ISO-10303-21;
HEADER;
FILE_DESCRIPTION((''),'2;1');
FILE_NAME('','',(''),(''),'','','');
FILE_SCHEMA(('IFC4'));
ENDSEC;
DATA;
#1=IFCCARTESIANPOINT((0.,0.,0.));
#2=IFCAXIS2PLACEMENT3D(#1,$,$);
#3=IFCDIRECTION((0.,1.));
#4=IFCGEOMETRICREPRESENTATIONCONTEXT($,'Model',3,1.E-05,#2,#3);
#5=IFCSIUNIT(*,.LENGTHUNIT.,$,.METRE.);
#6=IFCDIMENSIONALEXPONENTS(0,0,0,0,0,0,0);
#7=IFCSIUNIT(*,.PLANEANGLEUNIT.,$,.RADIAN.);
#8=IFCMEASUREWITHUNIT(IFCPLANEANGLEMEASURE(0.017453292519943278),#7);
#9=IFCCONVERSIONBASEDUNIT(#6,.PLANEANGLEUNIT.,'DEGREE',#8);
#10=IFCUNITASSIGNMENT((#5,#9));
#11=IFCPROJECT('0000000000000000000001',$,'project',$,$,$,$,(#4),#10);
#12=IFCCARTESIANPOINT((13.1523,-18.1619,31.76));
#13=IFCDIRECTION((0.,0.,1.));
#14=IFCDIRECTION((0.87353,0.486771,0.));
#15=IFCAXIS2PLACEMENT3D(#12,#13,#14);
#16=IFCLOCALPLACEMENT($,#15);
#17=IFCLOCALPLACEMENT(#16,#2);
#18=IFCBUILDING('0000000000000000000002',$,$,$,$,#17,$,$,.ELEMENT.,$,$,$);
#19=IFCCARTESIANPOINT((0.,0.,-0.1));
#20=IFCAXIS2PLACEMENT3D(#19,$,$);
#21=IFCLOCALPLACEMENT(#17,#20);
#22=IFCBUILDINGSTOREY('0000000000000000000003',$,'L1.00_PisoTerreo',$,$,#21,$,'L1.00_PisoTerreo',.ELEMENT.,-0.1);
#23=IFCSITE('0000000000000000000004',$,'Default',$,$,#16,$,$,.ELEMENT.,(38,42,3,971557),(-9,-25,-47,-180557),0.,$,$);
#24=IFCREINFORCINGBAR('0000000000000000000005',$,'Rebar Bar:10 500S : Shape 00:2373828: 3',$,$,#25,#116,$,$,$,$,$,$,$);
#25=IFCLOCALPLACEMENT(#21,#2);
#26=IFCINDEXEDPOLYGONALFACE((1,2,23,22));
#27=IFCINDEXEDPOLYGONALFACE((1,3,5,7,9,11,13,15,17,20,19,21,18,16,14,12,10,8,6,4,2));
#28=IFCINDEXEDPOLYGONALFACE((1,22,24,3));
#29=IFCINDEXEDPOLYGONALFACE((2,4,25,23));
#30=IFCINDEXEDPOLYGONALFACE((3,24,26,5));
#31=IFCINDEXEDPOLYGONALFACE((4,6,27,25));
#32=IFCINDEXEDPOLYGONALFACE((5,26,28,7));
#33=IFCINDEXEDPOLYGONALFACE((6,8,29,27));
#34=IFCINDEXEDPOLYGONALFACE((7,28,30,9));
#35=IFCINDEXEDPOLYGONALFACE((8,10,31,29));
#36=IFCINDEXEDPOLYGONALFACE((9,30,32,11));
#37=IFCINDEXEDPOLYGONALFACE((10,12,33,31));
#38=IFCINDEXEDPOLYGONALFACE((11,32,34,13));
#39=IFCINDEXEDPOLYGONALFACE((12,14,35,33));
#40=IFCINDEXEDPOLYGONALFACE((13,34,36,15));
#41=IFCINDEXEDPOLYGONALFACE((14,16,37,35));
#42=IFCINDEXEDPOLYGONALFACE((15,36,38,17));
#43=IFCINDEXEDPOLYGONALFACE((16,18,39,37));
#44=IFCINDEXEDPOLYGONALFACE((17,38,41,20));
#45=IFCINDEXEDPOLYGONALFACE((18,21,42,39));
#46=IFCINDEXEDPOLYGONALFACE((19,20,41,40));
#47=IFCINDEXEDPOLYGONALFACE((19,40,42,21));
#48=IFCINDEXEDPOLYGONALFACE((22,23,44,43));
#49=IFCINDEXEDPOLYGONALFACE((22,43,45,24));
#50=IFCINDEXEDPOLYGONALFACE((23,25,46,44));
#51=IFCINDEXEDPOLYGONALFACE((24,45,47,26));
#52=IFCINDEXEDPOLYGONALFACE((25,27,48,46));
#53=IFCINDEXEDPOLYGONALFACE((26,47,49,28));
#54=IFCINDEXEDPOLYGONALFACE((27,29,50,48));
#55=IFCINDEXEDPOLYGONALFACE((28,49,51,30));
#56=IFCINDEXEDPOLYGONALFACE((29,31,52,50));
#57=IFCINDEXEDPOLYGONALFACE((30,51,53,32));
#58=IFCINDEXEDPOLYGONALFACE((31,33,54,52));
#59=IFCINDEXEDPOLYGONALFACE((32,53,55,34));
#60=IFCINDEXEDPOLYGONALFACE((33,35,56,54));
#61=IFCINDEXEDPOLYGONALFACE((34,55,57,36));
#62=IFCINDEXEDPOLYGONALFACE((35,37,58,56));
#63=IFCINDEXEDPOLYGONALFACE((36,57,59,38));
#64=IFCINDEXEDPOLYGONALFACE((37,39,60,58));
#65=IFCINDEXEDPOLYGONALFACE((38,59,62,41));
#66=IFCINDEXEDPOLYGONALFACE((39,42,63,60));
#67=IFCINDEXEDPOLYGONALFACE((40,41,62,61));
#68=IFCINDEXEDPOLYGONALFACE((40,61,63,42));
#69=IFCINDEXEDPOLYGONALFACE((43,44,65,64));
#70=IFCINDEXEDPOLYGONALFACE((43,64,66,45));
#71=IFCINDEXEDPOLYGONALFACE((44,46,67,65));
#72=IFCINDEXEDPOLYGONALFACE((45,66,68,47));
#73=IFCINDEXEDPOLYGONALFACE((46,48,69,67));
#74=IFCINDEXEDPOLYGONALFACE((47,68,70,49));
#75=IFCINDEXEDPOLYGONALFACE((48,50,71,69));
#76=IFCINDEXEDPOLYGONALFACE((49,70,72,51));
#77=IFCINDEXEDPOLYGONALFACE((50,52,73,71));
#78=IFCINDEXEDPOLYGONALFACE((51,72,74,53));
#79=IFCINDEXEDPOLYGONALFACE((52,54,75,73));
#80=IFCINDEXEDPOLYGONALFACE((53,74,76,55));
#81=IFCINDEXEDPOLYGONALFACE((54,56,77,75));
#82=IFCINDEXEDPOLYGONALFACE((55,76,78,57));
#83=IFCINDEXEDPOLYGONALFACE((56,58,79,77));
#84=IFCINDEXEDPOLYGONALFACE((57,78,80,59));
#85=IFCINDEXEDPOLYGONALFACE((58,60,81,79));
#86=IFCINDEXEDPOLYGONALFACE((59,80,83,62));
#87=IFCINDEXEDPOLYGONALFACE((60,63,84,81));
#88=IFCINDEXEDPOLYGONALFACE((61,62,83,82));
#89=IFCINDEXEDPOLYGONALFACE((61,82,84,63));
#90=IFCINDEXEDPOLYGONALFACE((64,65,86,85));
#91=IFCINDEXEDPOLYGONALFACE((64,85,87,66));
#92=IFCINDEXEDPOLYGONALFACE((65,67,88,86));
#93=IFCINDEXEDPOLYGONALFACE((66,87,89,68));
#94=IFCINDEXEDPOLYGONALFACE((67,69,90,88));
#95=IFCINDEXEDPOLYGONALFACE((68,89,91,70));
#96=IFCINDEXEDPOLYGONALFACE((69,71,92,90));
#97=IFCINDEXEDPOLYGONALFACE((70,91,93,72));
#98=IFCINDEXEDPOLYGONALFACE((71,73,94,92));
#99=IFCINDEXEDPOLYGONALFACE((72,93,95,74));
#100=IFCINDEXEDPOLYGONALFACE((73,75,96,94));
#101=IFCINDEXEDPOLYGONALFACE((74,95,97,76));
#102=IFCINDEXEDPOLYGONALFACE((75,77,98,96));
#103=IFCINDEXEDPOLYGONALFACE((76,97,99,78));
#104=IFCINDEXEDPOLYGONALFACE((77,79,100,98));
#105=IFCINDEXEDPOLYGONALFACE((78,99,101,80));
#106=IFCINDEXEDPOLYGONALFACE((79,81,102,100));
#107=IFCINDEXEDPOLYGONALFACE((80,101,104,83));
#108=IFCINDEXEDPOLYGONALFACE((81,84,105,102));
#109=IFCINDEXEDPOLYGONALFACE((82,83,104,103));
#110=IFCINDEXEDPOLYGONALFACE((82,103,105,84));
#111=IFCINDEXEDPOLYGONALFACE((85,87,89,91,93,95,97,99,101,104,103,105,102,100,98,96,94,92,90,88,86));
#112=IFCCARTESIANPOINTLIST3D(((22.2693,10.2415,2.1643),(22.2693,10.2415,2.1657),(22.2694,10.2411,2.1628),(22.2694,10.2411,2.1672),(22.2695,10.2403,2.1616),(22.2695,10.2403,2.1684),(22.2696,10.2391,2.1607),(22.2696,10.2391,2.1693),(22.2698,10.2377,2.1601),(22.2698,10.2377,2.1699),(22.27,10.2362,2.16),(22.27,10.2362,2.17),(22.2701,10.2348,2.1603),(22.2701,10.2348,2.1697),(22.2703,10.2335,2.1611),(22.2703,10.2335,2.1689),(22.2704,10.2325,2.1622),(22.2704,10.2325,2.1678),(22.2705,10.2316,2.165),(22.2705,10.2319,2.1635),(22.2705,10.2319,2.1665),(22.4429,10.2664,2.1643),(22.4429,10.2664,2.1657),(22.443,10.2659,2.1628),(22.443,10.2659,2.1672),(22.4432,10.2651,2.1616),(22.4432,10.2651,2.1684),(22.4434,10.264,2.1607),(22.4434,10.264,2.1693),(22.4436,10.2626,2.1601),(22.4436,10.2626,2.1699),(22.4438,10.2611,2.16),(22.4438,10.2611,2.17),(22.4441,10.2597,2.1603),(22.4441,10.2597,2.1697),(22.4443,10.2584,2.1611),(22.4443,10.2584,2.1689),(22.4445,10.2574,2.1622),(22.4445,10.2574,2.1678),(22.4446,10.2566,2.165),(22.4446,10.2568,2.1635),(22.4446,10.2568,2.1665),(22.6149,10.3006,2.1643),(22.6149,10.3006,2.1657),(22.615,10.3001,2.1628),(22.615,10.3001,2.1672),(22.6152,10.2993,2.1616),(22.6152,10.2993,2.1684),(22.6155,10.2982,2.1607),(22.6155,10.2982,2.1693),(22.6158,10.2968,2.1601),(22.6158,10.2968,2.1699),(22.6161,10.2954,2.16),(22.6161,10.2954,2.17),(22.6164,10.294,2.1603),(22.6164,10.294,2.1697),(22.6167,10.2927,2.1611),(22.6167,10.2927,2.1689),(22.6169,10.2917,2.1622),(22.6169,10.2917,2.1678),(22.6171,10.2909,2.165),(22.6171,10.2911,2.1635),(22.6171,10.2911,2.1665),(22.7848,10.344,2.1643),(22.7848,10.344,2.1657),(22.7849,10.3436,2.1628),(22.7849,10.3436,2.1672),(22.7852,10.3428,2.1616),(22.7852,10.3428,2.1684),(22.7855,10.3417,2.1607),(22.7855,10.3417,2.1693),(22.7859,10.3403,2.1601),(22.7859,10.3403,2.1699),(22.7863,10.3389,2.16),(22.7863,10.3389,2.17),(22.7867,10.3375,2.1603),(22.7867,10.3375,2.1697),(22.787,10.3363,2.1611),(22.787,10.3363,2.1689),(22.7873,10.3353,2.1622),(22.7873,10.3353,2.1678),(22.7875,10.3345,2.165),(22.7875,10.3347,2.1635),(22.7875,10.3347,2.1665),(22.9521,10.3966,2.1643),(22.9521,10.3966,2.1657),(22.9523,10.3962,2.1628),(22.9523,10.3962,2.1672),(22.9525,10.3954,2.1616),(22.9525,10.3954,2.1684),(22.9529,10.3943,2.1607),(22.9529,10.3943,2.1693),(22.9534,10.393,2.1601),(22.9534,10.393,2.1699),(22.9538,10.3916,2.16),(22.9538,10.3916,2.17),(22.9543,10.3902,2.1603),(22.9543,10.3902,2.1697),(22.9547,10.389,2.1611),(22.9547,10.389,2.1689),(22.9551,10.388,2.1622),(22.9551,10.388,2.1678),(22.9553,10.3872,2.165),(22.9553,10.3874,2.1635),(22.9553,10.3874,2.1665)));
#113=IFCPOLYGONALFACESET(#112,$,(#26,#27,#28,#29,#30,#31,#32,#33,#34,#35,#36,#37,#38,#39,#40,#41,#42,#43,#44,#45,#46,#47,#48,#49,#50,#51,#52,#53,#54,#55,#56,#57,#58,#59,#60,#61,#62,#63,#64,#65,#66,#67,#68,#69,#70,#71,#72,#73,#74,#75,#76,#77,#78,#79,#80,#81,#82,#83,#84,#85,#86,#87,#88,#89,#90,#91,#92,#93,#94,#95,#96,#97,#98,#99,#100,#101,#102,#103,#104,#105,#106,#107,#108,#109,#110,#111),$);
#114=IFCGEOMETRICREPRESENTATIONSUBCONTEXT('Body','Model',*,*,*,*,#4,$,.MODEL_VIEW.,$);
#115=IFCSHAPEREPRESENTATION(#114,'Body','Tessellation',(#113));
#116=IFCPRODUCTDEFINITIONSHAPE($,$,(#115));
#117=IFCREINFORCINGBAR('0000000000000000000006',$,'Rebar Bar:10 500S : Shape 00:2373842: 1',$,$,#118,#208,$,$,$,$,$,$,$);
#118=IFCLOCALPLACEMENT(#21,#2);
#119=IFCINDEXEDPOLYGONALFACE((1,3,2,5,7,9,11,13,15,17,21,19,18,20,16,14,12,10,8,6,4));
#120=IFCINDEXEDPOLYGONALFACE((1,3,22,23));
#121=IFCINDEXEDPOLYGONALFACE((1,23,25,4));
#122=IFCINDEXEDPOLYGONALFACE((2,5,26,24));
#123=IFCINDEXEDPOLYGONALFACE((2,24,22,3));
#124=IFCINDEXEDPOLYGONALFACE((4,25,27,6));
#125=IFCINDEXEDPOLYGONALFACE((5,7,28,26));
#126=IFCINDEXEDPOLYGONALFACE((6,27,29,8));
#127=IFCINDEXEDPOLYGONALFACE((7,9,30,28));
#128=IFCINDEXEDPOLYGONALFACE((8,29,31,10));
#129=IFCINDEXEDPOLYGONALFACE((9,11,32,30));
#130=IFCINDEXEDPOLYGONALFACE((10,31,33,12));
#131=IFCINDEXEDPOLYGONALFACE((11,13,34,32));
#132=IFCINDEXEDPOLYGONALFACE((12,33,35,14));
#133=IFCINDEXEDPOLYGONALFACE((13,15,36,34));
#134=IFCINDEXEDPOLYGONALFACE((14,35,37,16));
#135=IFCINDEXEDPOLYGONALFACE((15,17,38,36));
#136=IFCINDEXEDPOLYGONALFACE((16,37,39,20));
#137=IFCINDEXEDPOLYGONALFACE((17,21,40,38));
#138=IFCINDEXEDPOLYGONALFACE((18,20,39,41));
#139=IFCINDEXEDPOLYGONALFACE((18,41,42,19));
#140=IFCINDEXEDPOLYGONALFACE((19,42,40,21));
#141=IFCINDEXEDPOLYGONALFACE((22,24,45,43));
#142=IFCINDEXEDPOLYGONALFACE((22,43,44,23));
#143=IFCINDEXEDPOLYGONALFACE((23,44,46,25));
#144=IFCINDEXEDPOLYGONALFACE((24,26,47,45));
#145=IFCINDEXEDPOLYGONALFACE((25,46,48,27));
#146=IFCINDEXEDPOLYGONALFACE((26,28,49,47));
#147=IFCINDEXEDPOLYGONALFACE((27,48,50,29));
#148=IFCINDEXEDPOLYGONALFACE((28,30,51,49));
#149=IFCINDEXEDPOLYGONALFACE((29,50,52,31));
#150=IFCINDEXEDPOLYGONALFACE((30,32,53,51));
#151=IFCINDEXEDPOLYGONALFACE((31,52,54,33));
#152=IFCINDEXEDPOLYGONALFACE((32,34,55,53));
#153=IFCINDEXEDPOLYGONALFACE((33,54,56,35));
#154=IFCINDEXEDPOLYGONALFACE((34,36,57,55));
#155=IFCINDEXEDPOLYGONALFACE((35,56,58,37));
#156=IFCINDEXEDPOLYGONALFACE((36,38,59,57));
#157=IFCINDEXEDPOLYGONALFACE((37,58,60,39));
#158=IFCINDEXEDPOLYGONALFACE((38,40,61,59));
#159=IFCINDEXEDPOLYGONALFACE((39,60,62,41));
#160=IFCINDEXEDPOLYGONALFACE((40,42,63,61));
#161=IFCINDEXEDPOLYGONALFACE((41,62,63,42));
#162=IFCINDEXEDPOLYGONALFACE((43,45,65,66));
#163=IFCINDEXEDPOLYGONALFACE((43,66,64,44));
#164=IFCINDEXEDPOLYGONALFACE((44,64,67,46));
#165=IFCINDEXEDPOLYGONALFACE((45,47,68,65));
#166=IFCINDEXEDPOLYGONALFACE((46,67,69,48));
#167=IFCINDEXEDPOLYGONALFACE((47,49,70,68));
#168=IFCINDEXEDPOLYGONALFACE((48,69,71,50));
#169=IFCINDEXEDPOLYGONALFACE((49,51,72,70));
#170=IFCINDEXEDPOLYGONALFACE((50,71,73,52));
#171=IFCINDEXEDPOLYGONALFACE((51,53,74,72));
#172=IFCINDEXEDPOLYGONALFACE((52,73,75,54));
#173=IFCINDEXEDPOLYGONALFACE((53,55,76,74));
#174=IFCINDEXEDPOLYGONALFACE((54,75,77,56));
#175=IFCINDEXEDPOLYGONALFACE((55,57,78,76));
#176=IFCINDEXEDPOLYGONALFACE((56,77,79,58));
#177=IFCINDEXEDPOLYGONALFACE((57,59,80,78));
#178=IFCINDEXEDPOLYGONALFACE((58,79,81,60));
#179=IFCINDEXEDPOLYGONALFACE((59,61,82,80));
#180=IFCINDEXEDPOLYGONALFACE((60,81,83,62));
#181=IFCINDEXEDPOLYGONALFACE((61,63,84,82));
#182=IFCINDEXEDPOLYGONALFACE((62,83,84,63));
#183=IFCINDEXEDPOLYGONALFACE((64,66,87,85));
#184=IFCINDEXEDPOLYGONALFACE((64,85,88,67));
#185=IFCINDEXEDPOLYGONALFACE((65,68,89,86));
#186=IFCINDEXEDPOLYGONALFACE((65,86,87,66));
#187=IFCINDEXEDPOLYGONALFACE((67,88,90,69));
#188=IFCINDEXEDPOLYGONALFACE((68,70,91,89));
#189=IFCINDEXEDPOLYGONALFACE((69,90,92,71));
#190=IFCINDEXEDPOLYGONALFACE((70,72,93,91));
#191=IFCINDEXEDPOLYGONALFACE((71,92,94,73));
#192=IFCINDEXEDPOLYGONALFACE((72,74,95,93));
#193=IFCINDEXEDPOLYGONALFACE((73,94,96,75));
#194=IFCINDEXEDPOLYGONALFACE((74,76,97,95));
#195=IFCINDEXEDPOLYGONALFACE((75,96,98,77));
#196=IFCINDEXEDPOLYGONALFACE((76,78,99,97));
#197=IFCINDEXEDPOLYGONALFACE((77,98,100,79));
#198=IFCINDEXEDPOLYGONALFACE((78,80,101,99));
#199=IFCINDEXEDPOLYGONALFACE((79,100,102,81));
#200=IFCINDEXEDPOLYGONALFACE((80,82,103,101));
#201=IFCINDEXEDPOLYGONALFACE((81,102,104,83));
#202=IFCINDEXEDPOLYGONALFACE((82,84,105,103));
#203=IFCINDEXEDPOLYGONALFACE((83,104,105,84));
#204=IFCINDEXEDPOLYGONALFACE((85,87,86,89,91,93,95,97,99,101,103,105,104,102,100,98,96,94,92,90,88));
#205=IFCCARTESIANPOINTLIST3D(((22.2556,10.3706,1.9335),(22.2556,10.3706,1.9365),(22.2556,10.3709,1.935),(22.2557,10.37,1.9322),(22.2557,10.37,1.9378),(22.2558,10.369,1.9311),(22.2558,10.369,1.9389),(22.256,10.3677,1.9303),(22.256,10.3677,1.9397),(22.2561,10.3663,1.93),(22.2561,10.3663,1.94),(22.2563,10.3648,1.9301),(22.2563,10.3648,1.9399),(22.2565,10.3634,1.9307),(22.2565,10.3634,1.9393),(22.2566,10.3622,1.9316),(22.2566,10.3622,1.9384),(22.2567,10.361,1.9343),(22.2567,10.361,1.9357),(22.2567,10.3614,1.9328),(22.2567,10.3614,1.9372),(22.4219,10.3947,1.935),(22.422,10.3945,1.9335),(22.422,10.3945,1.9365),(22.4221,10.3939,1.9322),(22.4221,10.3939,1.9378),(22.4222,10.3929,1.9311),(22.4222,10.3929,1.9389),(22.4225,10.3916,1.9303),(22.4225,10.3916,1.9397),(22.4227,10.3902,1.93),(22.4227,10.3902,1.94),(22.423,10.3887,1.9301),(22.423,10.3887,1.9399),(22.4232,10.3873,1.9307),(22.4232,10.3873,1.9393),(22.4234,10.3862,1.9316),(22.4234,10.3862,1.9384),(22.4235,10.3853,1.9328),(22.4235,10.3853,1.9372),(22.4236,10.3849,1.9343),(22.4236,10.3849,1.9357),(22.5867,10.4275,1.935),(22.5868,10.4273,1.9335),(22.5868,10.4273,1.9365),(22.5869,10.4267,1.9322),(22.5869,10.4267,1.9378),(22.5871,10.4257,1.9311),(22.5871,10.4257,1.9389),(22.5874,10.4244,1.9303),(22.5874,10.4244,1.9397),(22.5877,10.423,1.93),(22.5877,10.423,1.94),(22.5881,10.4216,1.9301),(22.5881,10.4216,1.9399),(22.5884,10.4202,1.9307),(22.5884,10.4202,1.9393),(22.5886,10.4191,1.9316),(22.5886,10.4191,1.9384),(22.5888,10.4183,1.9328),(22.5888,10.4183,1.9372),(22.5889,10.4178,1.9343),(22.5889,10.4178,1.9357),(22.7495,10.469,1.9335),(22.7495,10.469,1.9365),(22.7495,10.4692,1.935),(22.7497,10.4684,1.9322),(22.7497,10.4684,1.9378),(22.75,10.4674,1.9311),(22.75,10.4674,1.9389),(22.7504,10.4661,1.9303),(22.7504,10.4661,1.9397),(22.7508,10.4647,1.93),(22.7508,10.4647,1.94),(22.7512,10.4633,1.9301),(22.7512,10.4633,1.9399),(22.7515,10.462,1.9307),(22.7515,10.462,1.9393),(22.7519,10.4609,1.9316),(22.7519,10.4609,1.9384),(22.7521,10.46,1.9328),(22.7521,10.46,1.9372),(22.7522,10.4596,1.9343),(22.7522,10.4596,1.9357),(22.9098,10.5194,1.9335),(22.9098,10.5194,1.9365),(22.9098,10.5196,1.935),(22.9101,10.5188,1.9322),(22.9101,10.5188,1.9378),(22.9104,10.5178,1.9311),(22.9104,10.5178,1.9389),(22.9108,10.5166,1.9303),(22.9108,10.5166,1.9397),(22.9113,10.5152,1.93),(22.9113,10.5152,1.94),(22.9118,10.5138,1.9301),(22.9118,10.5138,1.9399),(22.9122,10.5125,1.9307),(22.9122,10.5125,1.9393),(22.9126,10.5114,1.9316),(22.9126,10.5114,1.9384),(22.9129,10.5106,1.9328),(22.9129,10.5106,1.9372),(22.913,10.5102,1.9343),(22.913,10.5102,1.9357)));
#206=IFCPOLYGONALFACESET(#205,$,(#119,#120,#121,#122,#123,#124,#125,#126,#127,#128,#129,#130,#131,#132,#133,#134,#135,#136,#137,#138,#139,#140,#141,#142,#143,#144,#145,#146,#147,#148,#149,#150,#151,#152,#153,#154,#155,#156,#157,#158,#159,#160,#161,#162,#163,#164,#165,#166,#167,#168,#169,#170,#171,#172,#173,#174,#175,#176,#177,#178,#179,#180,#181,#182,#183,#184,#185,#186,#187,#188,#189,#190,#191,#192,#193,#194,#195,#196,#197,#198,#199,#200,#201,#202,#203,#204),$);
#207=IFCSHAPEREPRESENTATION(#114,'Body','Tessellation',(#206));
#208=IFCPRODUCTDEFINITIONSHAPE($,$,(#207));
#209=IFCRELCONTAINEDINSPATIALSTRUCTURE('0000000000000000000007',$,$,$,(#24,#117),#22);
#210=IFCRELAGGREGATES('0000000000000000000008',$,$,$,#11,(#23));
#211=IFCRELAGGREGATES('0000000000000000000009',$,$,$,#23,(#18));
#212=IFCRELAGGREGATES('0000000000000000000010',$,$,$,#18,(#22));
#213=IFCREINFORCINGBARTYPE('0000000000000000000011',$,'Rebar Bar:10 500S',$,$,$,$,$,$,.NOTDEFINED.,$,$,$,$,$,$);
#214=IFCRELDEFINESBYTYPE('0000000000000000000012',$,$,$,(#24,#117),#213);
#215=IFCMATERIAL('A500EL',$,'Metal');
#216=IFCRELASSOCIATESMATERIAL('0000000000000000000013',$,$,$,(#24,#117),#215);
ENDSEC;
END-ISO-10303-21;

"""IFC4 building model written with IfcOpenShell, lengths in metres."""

from ifc_helpers import new_model, entity, si_unit, converted_unit, direction, frame, origin, place, context, subcontext, project, spatial, material, type_object, element, save


model = new_model("IFC4")

# Units and contexts
model_context = context("Model", 3, precision=1e-05, world=origin(), true_north=direction((0.0, 1.0)))
body_context = subcontext(model_context, "Body", "Model", "MODEL_VIEW")
ifc_project = project(units=[si_unit("LENGTHUNIT", "METRE"), converted_unit("PLANEANGLEUNIT", "DEGREE", entity("IfcPlaneAngleMeasure", 0.017453292519943278), si_unit("PLANEANGLEUNIT", "RADIAN"), dimensions=[0, 0, 0, 0, 0, 0, 0])], contexts=[model_context])

# Site, building, storey
site_placement = place(None, frame((13.1523, -18.1619, 31.76), z_axis=(0.0, 0.0, 1.0), x_axis=(0.87353, 0.486771, 0.0)))
site = spatial("IfcSite", under=ifc_project, at=site_placement, Name="Default", CompositionType="ELEMENT", RefLatitude=(38, 42, 3, 971557), RefLongitude=(-9, -25, -47, -180557), RefElevation=0.0)
building_placement = place(site_placement, origin())
building = spatial("IfcBuilding", under=site, at=building_placement, CompositionType="ELEMENT")
storey_placement = place(building_placement, frame((0.0, 0.0, -0.1)))
storey = spatial("IfcBuildingStorey", under=building, at=storey_placement, Name="L1.00_PisoTerreo", LongName="L1.00_PisoTerreo", CompositionType="ELEMENT", Elevation=-0.1)

# Reinforcing bars
ifc_material = material(Name="A500EL", Category="Metal")
reinforcing_bar_type_1 = type_object("IfcReinforcingBarType", Name="Rebar Bar:10 500S", PredefinedType="NOTDEFINED")
reinforcing_bar_1_placement = place(storey_placement, origin())
element("IfcReinforcingBar", 1, at=reinforcing_bar_1_placement, inside=storey, type_object=reinforcing_bar_type_1, material=ifc_material, Name="Rebar Bar:10 500S : Shape 00:2373828: 3", context=body_context, shape_type="AdvancedSweptSolid", body=[
    entity("IfcSweptDiskSolid", entity("IfcIndexedPolyCurve", entity("IfcCartesianPointList3D", [[22.9537, 10.3919, 2.165], [22.616, 10.2957, 2.165], [22.2699, 10.2366, 2.165]]), [entity("IfcArcIndex", [1, 2, 3])], False), 0.005, None, 0.0, 12.4055),
])
reinforcing_bar_2_placement = place(storey_placement, origin())
element("IfcReinforcingBar", 2, at=reinforcing_bar_2_placement, inside=storey, type_object=reinforcing_bar_type_1, material=ifc_material, Name="Rebar Bar:10 500S : Shape 00:2373842: 1", context=body_context, shape_type="AdvancedSweptSolid", body=[
    entity("IfcSweptDiskSolid", entity("IfcIndexedPolyCurve", entity("IfcCartesianPointList3D", [[22.2562, 10.3659, 1.935], [22.5878, 10.4226, 1.935], [22.9114, 10.5148, 1.935]]), [entity("IfcArcIndex", [1, 2, 3])], False), 0.005, None, 0.0, 12.3834),
])

save(model, "model.ifc")
